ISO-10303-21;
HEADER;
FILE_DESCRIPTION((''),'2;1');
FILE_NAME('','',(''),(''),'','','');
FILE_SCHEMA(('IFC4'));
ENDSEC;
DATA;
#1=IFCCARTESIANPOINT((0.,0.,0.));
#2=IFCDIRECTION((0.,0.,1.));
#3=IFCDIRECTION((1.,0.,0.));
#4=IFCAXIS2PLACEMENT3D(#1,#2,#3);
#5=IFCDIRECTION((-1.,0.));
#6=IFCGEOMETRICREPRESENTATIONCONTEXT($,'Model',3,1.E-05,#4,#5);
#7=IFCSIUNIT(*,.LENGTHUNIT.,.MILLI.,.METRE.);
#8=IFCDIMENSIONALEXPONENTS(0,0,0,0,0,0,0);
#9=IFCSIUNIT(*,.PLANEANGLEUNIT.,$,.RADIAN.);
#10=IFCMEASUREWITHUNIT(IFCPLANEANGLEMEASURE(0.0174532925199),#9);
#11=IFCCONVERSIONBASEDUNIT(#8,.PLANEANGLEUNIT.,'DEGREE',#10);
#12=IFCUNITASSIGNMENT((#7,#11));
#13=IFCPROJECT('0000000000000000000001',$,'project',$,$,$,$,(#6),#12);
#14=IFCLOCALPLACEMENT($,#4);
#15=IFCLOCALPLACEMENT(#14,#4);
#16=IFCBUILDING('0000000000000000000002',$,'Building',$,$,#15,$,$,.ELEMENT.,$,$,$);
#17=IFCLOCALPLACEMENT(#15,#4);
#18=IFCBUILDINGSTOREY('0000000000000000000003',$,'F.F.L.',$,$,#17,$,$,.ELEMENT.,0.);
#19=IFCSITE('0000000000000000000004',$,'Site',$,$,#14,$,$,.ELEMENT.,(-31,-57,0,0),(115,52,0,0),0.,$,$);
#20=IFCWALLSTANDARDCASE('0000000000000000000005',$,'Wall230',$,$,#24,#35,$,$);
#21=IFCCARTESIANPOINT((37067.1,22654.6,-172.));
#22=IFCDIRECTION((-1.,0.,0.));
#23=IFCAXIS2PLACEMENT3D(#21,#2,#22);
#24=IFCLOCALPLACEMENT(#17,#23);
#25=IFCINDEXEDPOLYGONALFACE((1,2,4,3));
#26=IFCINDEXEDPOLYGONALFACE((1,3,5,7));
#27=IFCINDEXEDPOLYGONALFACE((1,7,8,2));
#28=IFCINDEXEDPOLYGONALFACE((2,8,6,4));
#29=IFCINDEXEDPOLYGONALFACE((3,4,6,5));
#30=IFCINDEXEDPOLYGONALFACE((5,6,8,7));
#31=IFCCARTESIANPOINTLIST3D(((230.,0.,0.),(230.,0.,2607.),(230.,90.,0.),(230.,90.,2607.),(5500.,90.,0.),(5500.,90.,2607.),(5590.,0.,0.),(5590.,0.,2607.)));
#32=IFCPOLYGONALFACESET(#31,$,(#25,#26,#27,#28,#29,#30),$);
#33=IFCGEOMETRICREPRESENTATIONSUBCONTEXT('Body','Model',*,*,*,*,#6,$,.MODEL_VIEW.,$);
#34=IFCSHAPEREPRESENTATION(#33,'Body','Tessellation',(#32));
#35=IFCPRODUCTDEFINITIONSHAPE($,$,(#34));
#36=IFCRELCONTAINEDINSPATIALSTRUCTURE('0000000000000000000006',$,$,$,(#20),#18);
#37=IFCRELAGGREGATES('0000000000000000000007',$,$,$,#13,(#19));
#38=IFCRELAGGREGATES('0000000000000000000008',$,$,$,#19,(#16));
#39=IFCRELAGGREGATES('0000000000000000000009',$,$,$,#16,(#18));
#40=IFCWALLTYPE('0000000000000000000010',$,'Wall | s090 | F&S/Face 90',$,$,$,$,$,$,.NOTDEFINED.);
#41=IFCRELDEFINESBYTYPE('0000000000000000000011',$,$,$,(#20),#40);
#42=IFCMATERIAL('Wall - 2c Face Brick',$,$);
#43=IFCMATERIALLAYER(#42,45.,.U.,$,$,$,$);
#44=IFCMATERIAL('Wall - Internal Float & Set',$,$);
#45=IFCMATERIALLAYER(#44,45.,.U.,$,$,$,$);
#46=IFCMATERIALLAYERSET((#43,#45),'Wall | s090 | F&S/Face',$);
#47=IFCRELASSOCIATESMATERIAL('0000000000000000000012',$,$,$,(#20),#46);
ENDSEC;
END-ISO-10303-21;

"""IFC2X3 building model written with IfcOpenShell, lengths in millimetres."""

from ifc_helpers import new_model, entity, si_unit, converted_unit, direction, frame, origin_with_axes, place, context, subcontext, project, spatial, polyline, outline, extrude, material, layer, layer_set, layer_usage, type_object, element, save


model = new_model("IFC2X3")

# Units and contexts
model_context = context("Model", 3, precision=1e-05, world=origin_with_axes(), true_north=direction((-1.0, 0.0)))
body_context = subcontext(model_context, "Body", "Model", "MODEL_VIEW")
ifc_project = project(units=[si_unit("LENGTHUNIT", "METRE", prefix="MILLI"), converted_unit("PLANEANGLEUNIT", "DEGREE", entity("IfcPlaneAngleMeasure", 0.0174532925199), si_unit("PLANEANGLEUNIT", "RADIAN"), dimensions=[0, 0, 0, 0, 0, 0, 0])], contexts=[model_context])

# Site, building, storey
site_placement = place(None, origin_with_axes())
site = spatial("IfcSite", under=ifc_project, at=site_placement, Name="Site", CompositionType="ELEMENT", RefLatitude=(-31, -57, 0, 0), RefLongitude=(115, 52, 0, 0), RefElevation=0.0)
building_placement = place(site_placement, origin_with_axes())
building = spatial("IfcBuilding", under=site, at=building_placement, Name="Building", CompositionType="ELEMENT")
storey_placement = place(building_placement, origin_with_axes())
storey = spatial("IfcBuildingStorey", under=building, at=storey_placement, Name="F.F.L.", CompositionType="ELEMENT", Elevation=0.0)

# Shared definitions
ifc_material_1 = material(Name="Wall - 2c Face Brick")

# Shared definitions
ifc_material_2 = material(Name="Wall - Internal Float & Set")

# Wall
ifc_layer_1 = layer(ifc_material_1, 45.0, ventilated="UNKNOWN")
ifc_layer_2 = layer(ifc_material_2, 45.0, ventilated="UNKNOWN")
ifc_layer_set_1 = layer_set([ifc_layer_1, ifc_layer_2], Name="Wall | s090 | F&S/Face")
ifc_layer_usage_1 = layer_usage(ifc_layer_set_1, "AXIS2", "NEGATIVE", 90.0)
wall_type_1 = type_object("IfcWallType", Name="Wall | s090 | F&S/Face 90", PredefinedType="NOTDEFINED")
wall_1_placement = place(storey_placement, frame((37067.1, 22654.6, -172.0), z_axis=(0.0, 0.0, 1.0), x_axis=(-1.0, 0.0, 0.0)))
element("IfcWallStandardCase", 1, at=wall_1_placement, inside=storey, type_object=wall_type_1, material=ifc_layer_usage_1, Name="Wall230", context=body_context, shape_type="SweptSolid", body=[
    extrude(outline(polyline([(230.0, 0.0), (5590.0, 0.0), (5500.0, 90.0), (230.0, 90.0), (230.0, 0.0)])), origin_with_axes(), (0.0, 0.0, 1.0), 2607.0),
])

save(model, "model.ifc")
